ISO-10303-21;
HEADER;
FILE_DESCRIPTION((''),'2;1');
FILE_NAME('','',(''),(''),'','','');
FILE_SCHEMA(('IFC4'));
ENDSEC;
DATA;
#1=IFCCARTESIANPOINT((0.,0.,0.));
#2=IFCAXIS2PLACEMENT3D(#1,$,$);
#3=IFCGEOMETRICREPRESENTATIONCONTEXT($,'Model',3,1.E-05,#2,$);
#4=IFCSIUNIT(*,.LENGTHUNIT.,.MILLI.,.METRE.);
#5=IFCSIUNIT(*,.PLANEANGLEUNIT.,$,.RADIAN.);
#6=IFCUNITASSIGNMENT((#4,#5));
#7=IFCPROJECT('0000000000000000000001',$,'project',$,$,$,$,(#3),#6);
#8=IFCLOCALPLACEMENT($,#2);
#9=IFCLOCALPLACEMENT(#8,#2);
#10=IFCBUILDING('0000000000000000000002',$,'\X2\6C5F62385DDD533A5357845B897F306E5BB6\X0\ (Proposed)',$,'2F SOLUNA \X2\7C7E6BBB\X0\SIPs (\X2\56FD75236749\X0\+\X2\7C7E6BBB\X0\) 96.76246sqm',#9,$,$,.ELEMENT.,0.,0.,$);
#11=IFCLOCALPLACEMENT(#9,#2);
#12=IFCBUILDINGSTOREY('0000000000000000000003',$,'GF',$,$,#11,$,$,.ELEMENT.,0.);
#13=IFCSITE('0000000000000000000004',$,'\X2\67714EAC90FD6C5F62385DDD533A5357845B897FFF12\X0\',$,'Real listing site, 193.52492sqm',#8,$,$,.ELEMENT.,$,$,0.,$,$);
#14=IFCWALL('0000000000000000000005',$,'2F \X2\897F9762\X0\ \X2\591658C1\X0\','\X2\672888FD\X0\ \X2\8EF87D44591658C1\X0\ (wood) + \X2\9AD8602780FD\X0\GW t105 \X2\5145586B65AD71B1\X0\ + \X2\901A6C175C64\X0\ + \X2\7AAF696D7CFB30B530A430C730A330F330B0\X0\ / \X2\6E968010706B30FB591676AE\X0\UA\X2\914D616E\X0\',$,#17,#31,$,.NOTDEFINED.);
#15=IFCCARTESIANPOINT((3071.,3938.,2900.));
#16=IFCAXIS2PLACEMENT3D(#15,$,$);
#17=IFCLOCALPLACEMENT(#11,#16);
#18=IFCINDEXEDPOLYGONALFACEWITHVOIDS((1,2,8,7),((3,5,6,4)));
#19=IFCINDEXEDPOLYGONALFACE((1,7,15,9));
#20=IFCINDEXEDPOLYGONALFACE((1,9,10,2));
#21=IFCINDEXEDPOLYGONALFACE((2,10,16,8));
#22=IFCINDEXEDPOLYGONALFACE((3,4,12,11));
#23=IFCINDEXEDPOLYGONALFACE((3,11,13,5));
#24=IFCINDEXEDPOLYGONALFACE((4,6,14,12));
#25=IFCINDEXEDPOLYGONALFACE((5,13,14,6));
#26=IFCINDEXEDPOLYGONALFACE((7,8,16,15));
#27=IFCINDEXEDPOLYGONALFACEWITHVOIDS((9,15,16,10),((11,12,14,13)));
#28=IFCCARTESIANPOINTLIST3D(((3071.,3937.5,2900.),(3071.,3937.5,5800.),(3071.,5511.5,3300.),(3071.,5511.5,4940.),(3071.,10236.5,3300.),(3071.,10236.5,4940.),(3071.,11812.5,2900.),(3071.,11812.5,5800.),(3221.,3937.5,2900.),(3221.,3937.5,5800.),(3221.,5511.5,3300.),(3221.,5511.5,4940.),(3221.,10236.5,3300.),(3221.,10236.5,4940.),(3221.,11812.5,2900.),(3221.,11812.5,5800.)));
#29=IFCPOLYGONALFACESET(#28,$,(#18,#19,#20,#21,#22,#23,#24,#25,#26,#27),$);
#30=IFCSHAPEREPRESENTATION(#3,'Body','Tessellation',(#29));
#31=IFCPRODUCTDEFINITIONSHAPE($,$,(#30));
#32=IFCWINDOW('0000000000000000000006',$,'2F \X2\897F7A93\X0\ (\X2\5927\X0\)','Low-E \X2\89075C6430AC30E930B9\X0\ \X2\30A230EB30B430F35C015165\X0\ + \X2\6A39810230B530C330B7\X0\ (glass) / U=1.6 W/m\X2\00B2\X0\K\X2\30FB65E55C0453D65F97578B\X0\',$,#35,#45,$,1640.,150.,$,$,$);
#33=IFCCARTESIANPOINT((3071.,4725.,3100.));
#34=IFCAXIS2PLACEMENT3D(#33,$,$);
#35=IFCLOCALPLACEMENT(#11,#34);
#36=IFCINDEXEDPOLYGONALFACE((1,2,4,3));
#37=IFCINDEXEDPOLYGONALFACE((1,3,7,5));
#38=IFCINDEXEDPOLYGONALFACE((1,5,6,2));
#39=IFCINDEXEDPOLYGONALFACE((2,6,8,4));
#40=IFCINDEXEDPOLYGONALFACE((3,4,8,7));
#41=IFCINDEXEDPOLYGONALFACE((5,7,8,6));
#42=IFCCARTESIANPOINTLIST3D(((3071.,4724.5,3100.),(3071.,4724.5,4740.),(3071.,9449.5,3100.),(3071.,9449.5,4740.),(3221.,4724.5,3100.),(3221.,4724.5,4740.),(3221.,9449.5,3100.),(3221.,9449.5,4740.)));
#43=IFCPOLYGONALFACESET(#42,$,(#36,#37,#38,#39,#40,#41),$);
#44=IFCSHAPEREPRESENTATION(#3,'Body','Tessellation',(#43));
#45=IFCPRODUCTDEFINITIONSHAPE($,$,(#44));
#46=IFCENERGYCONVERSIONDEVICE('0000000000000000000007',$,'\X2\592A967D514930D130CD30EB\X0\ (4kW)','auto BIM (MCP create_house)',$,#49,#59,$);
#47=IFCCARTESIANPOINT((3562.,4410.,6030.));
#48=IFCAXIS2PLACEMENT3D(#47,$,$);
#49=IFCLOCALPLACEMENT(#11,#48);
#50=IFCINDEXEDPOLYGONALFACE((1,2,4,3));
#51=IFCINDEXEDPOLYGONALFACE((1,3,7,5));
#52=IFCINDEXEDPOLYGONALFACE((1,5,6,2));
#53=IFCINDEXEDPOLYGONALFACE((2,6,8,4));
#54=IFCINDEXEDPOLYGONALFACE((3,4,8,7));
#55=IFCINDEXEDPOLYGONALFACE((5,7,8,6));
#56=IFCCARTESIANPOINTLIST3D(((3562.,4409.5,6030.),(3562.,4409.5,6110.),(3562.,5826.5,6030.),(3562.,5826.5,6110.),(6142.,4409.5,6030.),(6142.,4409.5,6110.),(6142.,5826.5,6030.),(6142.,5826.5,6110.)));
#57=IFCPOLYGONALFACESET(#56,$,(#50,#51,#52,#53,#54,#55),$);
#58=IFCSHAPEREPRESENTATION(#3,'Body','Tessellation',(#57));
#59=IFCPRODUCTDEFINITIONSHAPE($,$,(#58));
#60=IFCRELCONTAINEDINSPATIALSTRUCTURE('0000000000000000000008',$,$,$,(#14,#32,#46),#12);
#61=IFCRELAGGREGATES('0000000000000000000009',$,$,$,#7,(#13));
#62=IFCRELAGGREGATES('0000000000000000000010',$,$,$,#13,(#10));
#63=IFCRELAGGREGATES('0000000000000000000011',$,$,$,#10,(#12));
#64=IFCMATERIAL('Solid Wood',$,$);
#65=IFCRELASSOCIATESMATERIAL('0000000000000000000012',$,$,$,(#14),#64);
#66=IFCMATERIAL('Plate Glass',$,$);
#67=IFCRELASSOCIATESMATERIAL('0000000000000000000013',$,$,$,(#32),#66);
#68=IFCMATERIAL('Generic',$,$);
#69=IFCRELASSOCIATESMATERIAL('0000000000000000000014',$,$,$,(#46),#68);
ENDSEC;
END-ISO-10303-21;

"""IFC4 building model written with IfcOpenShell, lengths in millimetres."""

from ifc_helpers import new_model, si_unit, frame, frame_2d, origin, place, context, project, spatial, rectangle, extrude, material, element, fill, save


model = new_model("IFC4")

# Units and contexts
model_context = context("Model", 3, precision=1e-05, world=origin())
ifc_project = project(units=[si_unit("LENGTHUNIT", "METRE", prefix="MILLI"), si_unit("PLANEANGLEUNIT", "RADIAN")], contexts=[model_context])

# Site, building, storey
site_placement = place(None, origin())
site = spatial("IfcSite", under=ifc_project, at=site_placement, Name="東京都江戸川区南葛西２", ObjectType="Real listing site, 193.52492sqm", CompositionType="ELEMENT", RefElevation=0.0)
building_placement = place(site_placement, origin())
building = spatial("IfcBuilding", under=site, at=building_placement, Name="江戸川区南葛西の家 (Proposed)", ObjectType="2F SOLUNA 籾殻SIPs (国産杉+籾殻) 96.76246sqm", CompositionType="ELEMENT", ElevationOfRefHeight=0.0, ElevationOfTerrain=0.0)
storey_placement = place(building_placement, origin())
storey = spatial("IfcBuildingStorey", under=building, at=storey_placement, Name="GF", CompositionType="ELEMENT", Elevation=0.0)

# Shared definitions
ifc_material_1 = material(Name="Solid Wood")

# Shared definitions
ifc_material_2 = material(Name="Plate Glass")

# Wall, opening, window
wall_1_placement = place(storey_placement, frame((3071.0, 3938.0, 2900.0)))
wall_1 = element("IfcWall", 1, at=wall_1_placement, inside=storey, material=ifc_material_1, Name="2F 西面 外壁", Description="木製 軸組外壁 (wood) + 高性能GW t105 充填断熱 + 通気層 + 窯業系サイディング / 準耐火・外皮UA配慮", PredefinedType="NOTDEFINED", context=model_context, shape_type="SweptSolid", body=[
    extrude(rectangle(XDim=150.0, YDim=7875.0, at=frame_2d((75.0, 3937.0))), frame((3071.0, 3938.0, 2900.0)), (0.0, 0.0, 1.0), 2900.0),
])
opening_1_placement = place(storey_placement, frame((3071.0, 4725.0, 3100.0)))
opening_1 = element("IfcOpeningElement", 2, at=opening_1_placement, cuts=wall_1, PredefinedType="NOTDEFINED", context=model_context, shape_type="SweptSolid", body=[
    extrude(rectangle(XDim=150.0, YDim=4725.0, at=frame_2d((75.0, 2362.0))), frame((3071.0, 4725.0, 3100.0)), (0.0, 0.0, 1.0), 1640.0),
])
window_1_placement = place(storey_placement, frame((3071.0, 4725.0, 3100.0)))
window_1 = element("IfcWindow", 3, at=window_1_placement, inside=storey, material=ifc_material_2, Name="2F 西窓 (大)", Description="Low-E 複層ガラス アルゴン封入 + 樹脂サッシ (glass) / U=1.6 W/m²K・日射取得型", OverallHeight=1640.0, OverallWidth=150.0, context=model_context, shape_type="SweptSolid", body=[
    extrude(rectangle(XDim=150.0, YDim=4725.0, at=frame_2d((75.0, 2362.0))), frame((3071.0, 4725.0, 3100.0)), (0.0, 0.0, 1.0), 1640.0),
])
fill(opening_1, window_1)

# Shared definitions
ifc_material_3 = material(Name="Generic")

# Energy conversion device
energy_conversion_device_placement = place(storey_placement, frame((3562.0, 4410.0, 6030.0)))
element("IfcEnergyConversionDevice", 4, at=energy_conversion_device_placement, inside=storey, material=ifc_material_3, Name="太陽光パネル (4kW)", Description="auto BIM (MCP create_house)", context=model_context, shape_type="SweptSolid", body=[
    extrude(rectangle(XDim=2580.0, YDim=1417.0, at=frame_2d((1290.0, 708.0))), frame((3562.0, 4410.0, 6030.0)), (0.0, 0.0, 1.0), 80.0),
])

save(model, "model.ifc")
